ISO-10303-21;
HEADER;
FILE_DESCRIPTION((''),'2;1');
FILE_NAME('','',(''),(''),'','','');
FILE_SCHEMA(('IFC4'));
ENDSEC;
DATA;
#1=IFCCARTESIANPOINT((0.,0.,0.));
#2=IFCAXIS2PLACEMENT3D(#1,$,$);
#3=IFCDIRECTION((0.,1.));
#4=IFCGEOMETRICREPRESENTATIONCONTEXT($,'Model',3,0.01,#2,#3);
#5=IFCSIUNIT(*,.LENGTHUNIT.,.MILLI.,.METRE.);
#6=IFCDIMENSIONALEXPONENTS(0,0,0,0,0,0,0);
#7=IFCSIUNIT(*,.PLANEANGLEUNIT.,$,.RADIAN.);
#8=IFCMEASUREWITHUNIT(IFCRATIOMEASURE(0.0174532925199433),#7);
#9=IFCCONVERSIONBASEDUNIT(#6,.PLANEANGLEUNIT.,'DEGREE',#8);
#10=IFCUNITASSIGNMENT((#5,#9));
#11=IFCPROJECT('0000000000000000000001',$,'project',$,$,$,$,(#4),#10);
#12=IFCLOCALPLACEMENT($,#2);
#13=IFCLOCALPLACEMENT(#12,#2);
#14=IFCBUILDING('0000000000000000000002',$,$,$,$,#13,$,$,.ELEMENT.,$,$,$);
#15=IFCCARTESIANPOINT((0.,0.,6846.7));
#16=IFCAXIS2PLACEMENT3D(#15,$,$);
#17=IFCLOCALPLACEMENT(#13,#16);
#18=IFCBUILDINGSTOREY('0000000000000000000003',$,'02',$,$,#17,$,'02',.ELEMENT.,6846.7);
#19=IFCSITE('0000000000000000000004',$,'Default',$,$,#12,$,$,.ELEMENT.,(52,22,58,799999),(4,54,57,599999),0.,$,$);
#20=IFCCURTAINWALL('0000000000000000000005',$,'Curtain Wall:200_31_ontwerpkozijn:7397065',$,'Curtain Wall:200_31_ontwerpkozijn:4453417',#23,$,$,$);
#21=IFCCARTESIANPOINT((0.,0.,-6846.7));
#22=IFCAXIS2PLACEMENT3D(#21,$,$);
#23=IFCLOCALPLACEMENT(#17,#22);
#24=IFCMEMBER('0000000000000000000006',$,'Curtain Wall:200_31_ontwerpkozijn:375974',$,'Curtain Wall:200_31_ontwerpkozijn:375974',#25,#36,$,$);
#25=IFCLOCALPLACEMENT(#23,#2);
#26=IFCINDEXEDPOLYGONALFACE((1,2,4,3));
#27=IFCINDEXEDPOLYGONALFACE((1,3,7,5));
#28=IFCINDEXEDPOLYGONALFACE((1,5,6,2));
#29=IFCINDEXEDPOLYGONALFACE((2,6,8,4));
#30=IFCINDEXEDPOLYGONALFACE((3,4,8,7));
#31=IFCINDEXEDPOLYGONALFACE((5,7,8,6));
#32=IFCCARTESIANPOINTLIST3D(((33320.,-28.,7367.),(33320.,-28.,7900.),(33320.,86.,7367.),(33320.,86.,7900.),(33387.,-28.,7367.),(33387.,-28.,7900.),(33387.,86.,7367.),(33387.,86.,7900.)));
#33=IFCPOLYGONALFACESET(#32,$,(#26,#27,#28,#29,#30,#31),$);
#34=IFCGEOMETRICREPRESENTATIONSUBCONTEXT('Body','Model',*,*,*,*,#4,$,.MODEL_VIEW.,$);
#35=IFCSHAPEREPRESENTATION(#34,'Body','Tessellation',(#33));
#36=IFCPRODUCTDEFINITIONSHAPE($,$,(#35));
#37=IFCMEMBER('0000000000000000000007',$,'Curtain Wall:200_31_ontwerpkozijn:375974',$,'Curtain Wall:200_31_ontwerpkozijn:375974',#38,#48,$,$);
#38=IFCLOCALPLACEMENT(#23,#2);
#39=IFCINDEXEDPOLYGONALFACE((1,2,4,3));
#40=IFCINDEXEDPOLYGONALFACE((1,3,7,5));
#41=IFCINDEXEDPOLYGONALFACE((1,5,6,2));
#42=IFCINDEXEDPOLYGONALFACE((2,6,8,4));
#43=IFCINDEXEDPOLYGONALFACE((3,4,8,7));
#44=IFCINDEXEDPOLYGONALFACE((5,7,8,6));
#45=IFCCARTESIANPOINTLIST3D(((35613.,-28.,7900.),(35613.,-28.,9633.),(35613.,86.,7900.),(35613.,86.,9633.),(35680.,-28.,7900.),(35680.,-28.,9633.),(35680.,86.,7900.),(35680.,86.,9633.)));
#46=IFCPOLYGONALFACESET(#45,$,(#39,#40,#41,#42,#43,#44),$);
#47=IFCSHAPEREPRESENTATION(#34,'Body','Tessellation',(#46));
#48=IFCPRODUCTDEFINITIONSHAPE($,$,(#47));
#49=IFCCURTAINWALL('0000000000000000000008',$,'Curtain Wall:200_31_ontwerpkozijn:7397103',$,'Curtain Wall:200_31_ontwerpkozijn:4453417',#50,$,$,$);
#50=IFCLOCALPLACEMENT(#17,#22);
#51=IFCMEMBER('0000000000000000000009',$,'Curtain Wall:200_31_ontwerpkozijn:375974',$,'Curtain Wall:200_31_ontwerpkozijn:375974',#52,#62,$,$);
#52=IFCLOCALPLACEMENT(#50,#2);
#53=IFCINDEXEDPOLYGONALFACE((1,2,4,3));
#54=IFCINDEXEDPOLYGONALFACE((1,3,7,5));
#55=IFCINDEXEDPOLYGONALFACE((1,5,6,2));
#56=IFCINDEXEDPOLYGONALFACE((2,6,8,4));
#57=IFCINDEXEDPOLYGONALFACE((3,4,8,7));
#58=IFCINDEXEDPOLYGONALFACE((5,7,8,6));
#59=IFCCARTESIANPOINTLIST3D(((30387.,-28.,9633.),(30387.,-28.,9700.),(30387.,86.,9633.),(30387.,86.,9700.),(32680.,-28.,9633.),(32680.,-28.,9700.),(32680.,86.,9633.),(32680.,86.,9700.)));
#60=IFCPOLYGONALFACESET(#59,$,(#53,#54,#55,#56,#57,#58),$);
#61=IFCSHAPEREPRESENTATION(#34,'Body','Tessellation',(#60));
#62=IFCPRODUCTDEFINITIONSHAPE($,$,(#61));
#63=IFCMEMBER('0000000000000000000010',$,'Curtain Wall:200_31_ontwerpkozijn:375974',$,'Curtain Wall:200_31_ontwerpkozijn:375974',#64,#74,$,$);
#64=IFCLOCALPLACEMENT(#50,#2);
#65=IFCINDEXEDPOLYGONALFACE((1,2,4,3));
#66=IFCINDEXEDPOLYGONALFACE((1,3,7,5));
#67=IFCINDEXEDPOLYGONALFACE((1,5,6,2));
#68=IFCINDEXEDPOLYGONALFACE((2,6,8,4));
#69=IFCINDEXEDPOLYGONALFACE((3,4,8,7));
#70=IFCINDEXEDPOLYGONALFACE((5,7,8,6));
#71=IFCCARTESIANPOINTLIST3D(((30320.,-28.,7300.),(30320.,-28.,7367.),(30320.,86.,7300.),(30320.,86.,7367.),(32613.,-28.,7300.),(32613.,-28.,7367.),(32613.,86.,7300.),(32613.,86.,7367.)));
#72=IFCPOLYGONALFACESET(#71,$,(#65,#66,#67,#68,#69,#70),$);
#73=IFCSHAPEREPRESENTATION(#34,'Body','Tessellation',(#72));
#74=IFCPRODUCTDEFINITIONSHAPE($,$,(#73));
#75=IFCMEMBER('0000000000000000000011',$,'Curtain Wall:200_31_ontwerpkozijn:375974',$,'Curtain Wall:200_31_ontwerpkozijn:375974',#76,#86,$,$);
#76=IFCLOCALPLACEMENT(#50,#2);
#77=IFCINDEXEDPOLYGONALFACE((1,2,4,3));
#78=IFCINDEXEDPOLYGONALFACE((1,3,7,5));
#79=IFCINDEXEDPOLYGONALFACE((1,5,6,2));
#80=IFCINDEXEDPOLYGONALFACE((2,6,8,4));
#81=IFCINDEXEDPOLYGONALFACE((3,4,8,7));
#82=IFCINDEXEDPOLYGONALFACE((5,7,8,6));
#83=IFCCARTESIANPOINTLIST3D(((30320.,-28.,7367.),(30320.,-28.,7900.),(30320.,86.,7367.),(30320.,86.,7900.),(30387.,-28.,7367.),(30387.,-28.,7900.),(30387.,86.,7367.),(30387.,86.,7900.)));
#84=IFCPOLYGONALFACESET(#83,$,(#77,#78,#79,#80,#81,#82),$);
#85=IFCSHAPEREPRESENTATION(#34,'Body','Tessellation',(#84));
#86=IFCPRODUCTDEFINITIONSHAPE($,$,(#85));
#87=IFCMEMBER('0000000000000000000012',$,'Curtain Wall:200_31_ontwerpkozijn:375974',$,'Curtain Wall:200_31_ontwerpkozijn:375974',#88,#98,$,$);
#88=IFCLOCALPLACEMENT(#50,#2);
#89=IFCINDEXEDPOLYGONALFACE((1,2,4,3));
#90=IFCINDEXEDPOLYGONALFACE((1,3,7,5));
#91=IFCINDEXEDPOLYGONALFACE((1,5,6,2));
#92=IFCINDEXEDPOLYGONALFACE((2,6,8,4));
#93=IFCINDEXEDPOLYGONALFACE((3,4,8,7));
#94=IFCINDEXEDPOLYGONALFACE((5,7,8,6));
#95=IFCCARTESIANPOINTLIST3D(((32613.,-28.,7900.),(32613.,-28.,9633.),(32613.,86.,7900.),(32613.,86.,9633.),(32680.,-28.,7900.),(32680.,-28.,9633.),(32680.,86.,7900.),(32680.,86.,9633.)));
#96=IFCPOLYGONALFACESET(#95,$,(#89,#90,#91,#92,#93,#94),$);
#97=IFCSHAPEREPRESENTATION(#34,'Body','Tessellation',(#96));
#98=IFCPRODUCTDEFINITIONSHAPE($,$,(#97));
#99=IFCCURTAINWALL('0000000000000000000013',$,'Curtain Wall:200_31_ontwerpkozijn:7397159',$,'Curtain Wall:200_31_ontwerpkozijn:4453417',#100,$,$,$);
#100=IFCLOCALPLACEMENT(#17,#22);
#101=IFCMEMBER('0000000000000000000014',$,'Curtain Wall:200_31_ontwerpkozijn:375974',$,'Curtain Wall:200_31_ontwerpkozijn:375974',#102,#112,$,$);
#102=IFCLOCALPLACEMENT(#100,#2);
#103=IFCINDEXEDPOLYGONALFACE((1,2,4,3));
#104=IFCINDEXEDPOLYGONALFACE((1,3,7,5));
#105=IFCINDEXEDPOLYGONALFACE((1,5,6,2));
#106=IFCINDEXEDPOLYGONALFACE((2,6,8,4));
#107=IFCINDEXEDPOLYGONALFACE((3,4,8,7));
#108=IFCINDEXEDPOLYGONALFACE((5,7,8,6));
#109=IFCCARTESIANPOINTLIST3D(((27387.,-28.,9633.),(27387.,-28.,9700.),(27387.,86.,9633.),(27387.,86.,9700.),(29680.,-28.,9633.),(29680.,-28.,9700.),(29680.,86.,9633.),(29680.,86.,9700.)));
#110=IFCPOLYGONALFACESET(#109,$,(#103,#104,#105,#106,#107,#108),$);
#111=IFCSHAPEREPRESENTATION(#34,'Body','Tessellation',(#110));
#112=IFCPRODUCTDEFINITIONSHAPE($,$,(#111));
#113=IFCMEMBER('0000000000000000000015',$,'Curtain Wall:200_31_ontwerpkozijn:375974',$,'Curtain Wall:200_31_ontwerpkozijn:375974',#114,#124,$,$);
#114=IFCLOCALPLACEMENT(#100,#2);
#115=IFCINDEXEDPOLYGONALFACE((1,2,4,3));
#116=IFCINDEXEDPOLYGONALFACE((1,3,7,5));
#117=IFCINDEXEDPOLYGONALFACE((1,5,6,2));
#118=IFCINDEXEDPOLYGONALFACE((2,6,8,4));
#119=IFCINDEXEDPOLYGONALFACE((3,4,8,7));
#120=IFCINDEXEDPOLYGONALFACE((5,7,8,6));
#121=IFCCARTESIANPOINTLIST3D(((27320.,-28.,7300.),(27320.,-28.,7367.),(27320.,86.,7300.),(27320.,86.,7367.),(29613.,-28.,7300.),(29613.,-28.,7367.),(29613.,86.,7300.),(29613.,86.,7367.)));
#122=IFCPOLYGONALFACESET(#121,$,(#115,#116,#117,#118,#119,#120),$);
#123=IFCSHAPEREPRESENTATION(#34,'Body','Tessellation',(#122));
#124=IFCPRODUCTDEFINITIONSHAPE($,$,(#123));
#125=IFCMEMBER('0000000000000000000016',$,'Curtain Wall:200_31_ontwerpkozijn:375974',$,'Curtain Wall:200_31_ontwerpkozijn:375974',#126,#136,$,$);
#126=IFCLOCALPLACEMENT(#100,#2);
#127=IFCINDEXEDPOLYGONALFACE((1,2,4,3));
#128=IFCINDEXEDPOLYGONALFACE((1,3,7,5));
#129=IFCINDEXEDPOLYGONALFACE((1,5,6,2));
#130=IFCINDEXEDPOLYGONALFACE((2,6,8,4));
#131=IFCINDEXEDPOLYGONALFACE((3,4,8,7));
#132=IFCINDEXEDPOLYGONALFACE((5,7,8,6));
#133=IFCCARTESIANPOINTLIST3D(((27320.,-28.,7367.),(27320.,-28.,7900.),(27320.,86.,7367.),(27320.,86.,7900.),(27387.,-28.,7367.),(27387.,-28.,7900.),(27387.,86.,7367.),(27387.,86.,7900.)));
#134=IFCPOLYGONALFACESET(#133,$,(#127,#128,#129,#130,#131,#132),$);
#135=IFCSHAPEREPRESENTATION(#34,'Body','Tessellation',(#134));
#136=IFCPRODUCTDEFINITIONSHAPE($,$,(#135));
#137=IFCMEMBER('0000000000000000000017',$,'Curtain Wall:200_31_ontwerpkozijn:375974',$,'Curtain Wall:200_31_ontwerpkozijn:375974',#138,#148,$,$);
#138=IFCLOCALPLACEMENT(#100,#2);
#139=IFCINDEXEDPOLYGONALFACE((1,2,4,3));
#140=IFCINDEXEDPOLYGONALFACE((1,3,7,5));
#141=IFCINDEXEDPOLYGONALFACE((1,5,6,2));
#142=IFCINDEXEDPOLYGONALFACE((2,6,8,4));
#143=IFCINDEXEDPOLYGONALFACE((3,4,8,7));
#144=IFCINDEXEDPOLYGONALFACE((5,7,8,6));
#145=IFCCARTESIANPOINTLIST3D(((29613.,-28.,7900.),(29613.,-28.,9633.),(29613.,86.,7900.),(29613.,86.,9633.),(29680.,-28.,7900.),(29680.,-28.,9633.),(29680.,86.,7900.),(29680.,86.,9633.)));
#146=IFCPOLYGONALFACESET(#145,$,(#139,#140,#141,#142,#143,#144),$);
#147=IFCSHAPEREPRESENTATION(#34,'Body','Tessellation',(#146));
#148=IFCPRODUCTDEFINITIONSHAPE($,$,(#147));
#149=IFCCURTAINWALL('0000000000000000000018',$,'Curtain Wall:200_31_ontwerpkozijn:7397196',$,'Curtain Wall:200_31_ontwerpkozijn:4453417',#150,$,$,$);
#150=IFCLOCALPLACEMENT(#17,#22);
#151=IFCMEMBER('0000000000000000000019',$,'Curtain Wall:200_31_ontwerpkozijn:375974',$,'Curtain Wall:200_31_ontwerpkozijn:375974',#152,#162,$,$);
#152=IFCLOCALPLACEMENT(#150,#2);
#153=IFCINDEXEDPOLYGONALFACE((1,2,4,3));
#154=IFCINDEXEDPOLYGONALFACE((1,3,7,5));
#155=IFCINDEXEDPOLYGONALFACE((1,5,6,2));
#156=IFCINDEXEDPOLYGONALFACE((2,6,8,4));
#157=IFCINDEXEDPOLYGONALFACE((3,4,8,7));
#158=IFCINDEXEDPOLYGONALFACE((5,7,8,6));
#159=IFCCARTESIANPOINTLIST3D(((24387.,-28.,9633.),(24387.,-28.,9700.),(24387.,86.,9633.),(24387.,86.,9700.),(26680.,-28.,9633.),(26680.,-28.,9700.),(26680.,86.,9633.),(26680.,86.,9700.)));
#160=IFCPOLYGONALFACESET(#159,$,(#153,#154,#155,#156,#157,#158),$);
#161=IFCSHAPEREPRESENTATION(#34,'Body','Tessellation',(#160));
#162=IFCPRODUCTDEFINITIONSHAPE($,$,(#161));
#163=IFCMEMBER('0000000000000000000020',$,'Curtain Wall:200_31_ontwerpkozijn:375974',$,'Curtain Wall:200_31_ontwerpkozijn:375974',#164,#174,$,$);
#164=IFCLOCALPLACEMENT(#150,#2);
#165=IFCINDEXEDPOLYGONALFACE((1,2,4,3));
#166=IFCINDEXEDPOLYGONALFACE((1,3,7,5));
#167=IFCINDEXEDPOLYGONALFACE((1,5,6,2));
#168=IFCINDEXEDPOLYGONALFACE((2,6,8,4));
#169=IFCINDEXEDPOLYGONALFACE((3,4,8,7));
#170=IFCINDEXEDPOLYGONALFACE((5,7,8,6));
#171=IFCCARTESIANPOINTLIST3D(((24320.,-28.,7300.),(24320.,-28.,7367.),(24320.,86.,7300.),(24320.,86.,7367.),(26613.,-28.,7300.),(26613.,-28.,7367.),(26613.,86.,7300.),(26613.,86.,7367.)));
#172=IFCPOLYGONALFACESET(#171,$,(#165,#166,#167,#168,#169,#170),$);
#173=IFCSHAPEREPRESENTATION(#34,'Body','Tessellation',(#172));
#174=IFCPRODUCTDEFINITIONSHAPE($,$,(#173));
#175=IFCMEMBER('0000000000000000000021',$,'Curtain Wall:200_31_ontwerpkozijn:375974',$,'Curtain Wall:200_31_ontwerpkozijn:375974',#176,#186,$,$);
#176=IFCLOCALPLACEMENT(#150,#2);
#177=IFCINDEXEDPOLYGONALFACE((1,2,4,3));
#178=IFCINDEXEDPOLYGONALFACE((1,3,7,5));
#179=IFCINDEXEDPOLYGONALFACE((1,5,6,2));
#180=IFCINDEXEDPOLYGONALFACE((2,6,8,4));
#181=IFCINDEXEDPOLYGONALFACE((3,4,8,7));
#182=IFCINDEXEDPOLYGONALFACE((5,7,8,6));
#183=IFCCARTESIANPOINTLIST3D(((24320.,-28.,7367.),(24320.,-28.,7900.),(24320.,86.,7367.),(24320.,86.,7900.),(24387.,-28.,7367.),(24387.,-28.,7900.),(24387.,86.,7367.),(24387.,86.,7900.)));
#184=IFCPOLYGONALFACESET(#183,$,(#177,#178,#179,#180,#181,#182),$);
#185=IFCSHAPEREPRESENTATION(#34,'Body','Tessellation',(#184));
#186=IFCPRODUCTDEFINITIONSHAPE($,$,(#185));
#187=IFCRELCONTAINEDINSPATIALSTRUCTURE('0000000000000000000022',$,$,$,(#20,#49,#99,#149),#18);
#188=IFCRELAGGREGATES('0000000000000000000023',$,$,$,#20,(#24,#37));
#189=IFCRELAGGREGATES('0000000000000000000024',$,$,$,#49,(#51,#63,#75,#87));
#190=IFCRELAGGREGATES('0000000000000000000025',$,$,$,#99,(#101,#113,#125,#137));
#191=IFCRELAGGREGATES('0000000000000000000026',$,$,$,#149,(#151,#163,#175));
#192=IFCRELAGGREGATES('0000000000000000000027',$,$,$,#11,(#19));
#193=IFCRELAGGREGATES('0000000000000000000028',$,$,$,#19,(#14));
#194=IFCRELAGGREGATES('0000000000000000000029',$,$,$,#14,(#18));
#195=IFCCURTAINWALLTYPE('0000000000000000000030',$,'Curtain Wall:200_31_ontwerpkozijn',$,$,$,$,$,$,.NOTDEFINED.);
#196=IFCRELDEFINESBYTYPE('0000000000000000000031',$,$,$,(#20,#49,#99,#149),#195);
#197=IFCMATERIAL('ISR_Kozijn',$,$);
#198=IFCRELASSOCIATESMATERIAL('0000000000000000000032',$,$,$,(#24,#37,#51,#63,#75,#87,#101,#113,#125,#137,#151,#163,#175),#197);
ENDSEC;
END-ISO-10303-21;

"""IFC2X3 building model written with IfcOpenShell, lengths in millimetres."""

from ifc_helpers import new_model, entity, si_unit, converted_unit, direction, frame, frame_2d, origin, origin_2d_with_axis, place, context, subcontext, project, spatial, rectangle, extrude, material, type_object, element, aggregate, save


model = new_model("IFC2X3")

# Units and contexts
model_context = context("Model", 3, precision=0.01, world=origin(), true_north=direction((0.0, 1.0)))
body_context = subcontext(model_context, "Body", "Model", "MODEL_VIEW")
ifc_project = project(units=[si_unit("LENGTHUNIT", "METRE", prefix="MILLI"), converted_unit("PLANEANGLEUNIT", "DEGREE", entity("IfcRatioMeasure", 0.0174532925199433), si_unit("PLANEANGLEUNIT", "RADIAN"), dimensions=[0, 0, 0, 0, 0, 0, 0])], contexts=[model_context])

# Site, building, storey
site_placement = place(None, origin())
site = spatial("IfcSite", under=ifc_project, at=site_placement, Name="Default", CompositionType="ELEMENT", RefLatitude=(52, 22, 58, 799999), RefLongitude=(4, 54, 57, 599999), RefElevation=0.0)
building_placement = place(site_placement, origin())
building = spatial("IfcBuilding", under=site, at=building_placement, CompositionType="ELEMENT")
storey_placement = place(building_placement, frame((0.0, 0.0, 6846.7)))
storey = spatial("IfcBuildingStorey", under=building, at=storey_placement, Name="02", LongName="02", CompositionType="ELEMENT", Elevation=6846.7)

# Curtain walls, members
curtain_wall_type = type_object("IfcCurtainWallType", Name="Curtain Wall:200_31_ontwerpkozijn", PredefinedType="NOTDEFINED")
ifc_material = material(Name="ISR_Kozijn")
curtain_wall_1_placement = place(storey_placement, frame((0.0, 0.0, -6846.7)))
curtain_wall_1 = element("IfcCurtainWall", 1, at=curtain_wall_1_placement, inside=storey, type_object=curtain_wall_type, Name="Curtain Wall:200_31_ontwerpkozijn:7397065", ObjectType="Curtain Wall:200_31_ontwerpkozijn:4453417")
member_1_placement = place(curtain_wall_1_placement, origin())
member_1 = element("IfcMember", 2, at=member_1_placement, material=ifc_material, Name="Curtain Wall:200_31_ontwerpkozijn:375974", ObjectType="Curtain Wall:200_31_ontwerpkozijn:375974", context=body_context, shape_type="SweptSolid", body=[
    extrude(rectangle(XDim=67.0, YDim=114.0, at=origin_2d_with_axis()), frame((33353.5, 29.0, 7367.0), z_axis=(0.0, 0.0, 1.0), x_axis=(-1.0, 0.0, 0.0)), (0.0, 0.0, 1.0), 533.0),
])
member_2_placement = place(curtain_wall_1_placement, origin())
member_2 = element("IfcMember", 3, at=member_2_placement, material=ifc_material, Name="Curtain Wall:200_31_ontwerpkozijn:375974", ObjectType="Curtain Wall:200_31_ontwerpkozijn:375974", context=body_context, shape_type="SweptSolid", body=[
    extrude(rectangle(XDim=67.0, YDim=114.0, at=origin_2d_with_axis()), frame((35646.5, 29.0, 9633.0), z_axis=(0.0, 0.0, -1.0), x_axis=(-1.0, 0.0, 0.0)), (0.0, 0.0, 1.0), 1733.0),
])
aggregate(curtain_wall_1, [member_1, member_2])
curtain_wall_2_placement = place(storey_placement, frame((0.0, 0.0, -6846.7)))
curtain_wall_2 = element("IfcCurtainWall", 4, at=curtain_wall_2_placement, inside=storey, type_object=curtain_wall_type, Name="Curtain Wall:200_31_ontwerpkozijn:7397103", ObjectType="Curtain Wall:200_31_ontwerpkozijn:4453417")
member_3_placement = place(curtain_wall_2_placement, origin())
member_3 = element("IfcMember", 5, at=member_3_placement, material=ifc_material, Name="Curtain Wall:200_31_ontwerpkozijn:375974", ObjectType="Curtain Wall:200_31_ontwerpkozijn:375974", context=body_context, shape_type="SweptSolid", body=[
    extrude(rectangle(XDim=67.0, YDim=114.0, at=frame_2d((0.0, 0.0), x_axis=(1.0, 0.0))), frame((30387.0, 29.0, 9666.5), z_axis=(1.0, 0.0, 0.0), x_axis=(0.0, 0.0, -1.0)), (0.0, 0.0, 1.0), 2293.0),
])
member_4_placement = place(curtain_wall_2_placement, origin())
member_4 = element("IfcMember", 6, at=member_4_placement, material=ifc_material, Name="Curtain Wall:200_31_ontwerpkozijn:375974", ObjectType="Curtain Wall:200_31_ontwerpkozijn:375974", context=body_context, shape_type="SweptSolid", body=[
    extrude(rectangle(XDim=67.0, YDim=114.0, at=frame_2d((0.0, 0.0), x_axis=(1.0, 0.0))), frame((32613.0, 29.0, 7333.5), z_axis=(-1.0, 0.0, 0.0), x_axis=(0.0, 0.0, -1.0)), (0.0, 0.0, 1.0), 2293.0),
])
member_5_placement = place(curtain_wall_2_placement, origin())
member_5 = element("IfcMember", 7, at=member_5_placement, material=ifc_material, Name="Curtain Wall:200_31_ontwerpkozijn:375974", ObjectType="Curtain Wall:200_31_ontwerpkozijn:375974", context=body_context, shape_type="SweptSolid", body=[
    extrude(rectangle(XDim=67.0, YDim=114.0, at=origin_2d_with_axis()), frame((30353.5, 29.0, 7367.0), z_axis=(0.0, 0.0, 1.0), x_axis=(-1.0, 0.0, 0.0)), (0.0, 0.0, 1.0), 533.0),
])
member_6_placement = place(curtain_wall_2_placement, origin())
member_6 = element("IfcMember", 8, at=member_6_placement, material=ifc_material, Name="Curtain Wall:200_31_ontwerpkozijn:375974", ObjectType="Curtain Wall:200_31_ontwerpkozijn:375974", context=body_context, shape_type="SweptSolid", body=[
    extrude(rectangle(XDim=67.0, YDim=114.0, at=origin_2d_with_axis()), frame((32646.5, 29.0, 9633.0), z_axis=(0.0, 0.0, -1.0), x_axis=(-1.0, 0.0, 0.0)), (0.0, 0.0, 1.0), 1733.0),
])
aggregate(curtain_wall_2, [member_3, member_4, member_5, member_6])
curtain_wall_3_placement = place(storey_placement, frame((0.0, 0.0, -6846.7)))
curtain_wall_3 = element("IfcCurtainWall", 9, at=curtain_wall_3_placement, inside=storey, type_object=curtain_wall_type, Name="Curtain Wall:200_31_ontwerpkozijn:7397159", ObjectType="Curtain Wall:200_31_ontwerpkozijn:4453417")
member_7_placement = place(curtain_wall_3_placement, origin())
member_7 = element("IfcMember", 10, at=member_7_placement, material=ifc_material, Name="Curtain Wall:200_31_ontwerpkozijn:375974", ObjectType="Curtain Wall:200_31_ontwerpkozijn:375974", context=body_context, shape_type="SweptSolid", body=[
    extrude(rectangle(XDim=67.0, YDim=114.0, at=frame_2d((0.0, 0.0), x_axis=(1.0, 0.0))), frame((27387.0, 29.0, 9666.5), z_axis=(1.0, 0.0, 0.0), x_axis=(0.0, 0.0, -1.0)), (0.0, 0.0, 1.0), 2293.0),
])
member_8_placement = place(curtain_wall_3_placement, origin())
member_8 = element("IfcMember", 11, at=member_8_placement, material=ifc_material, Name="Curtain Wall:200_31_ontwerpkozijn:375974", ObjectType="Curtain Wall:200_31_ontwerpkozijn:375974", context=body_context, shape_type="SweptSolid", body=[
    extrude(rectangle(XDim=67.0, YDim=114.0, at=frame_2d((0.0, 0.0), x_axis=(1.0, 0.0))), frame((29613.0, 29.0, 7333.5), z_axis=(-1.0, 0.0, 0.0), x_axis=(0.0, 0.0, -1.0)), (0.0, 0.0, 1.0), 2293.0),
])
member_9_placement = place(curtain_wall_3_placement, origin())
member_9 = element("IfcMember", 12, at=member_9_placement, material=ifc_material, Name="Curtain Wall:200_31_ontwerpkozijn:375974", ObjectType="Curtain Wall:200_31_ontwerpkozijn:375974", context=body_context, shape_type="SweptSolid", body=[
    extrude(rectangle(XDim=67.0, YDim=114.0, at=origin_2d_with_axis()), frame((27353.5, 29.0, 7367.0), z_axis=(0.0, 0.0, 1.0), x_axis=(-1.0, 0.0, 0.0)), (0.0, 0.0, 1.0), 533.0),
])
member_10_placement = place(curtain_wall_3_placement, origin())
member_10 = element("IfcMember", 13, at=member_10_placement, material=ifc_material, Name="Curtain Wall:200_31_ontwerpkozijn:375974", ObjectType="Curtain Wall:200_31_ontwerpkozijn:375974", context=body_context, shape_type="SweptSolid", body=[
    extrude(rectangle(XDim=67.0, YDim=114.0, at=origin_2d_with_axis()), frame((29646.5, 29.0, 9633.0), z_axis=(0.0, 0.0, -1.0), x_axis=(-1.0, 0.0, 0.0)), (0.0, 0.0, 1.0), 1733.0),
])
aggregate(curtain_wall_3, [member_7, member_8, member_9, member_10])
curtain_wall_4_placement = place(storey_placement, frame((0.0, 0.0, -6846.7)))
curtain_wall_4 = element("IfcCurtainWall", 14, at=curtain_wall_4_placement, inside=storey, type_object=curtain_wall_type, Name="Curtain Wall:200_31_ontwerpkozijn:7397196", ObjectType="Curtain Wall:200_31_ontwerpkozijn:4453417")
member_11_placement = place(curtain_wall_4_placement, origin())
member_11 = element("IfcMember", 15, at=member_11_placement, material=ifc_material, Name="Curtain Wall:200_31_ontwerpkozijn:375974", ObjectType="Curtain Wall:200_31_ontwerpkozijn:375974", context=body_context, shape_type="SweptSolid", body=[
    extrude(rectangle(XDim=67.0, YDim=114.0, at=frame_2d((0.0, 0.0), x_axis=(1.0, 0.0))), frame((24387.0, 29.0, 9666.5), z_axis=(1.0, 0.0, 0.0), x_axis=(0.0, 0.0, -1.0)), (0.0, 0.0, 1.0), 2293.0),
])
member_12_placement = place(curtain_wall_4_placement, origin())
member_12 = element("IfcMember", 16, at=member_12_placement, material=ifc_material, Name="Curtain Wall:200_31_ontwerpkozijn:375974", ObjectType="Curtain Wall:200_31_ontwerpkozijn:375974", context=body_context, shape_type="SweptSolid", body=[
    extrude(rectangle(XDim=67.0, YDim=114.0, at=frame_2d((0.0, 0.0), x_axis=(1.0, 0.0))), frame((26613.0, 29.0, 7333.5), z_axis=(-1.0, 0.0, 0.0), x_axis=(0.0, 0.0, -1.0)), (0.0, 0.0, 1.0), 2293.0),
])
member_13_placement = place(curtain_wall_4_placement, origin())
member_13 = element("IfcMember", 17, at=member_13_placement, material=ifc_material, Name="Curtain Wall:200_31_ontwerpkozijn:375974", ObjectType="Curtain Wall:200_31_ontwerpkozijn:375974", context=body_context, shape_type="SweptSolid", body=[
    extrude(rectangle(XDim=67.0, YDim=114.0, at=origin_2d_with_axis()), frame((24353.5, 29.0, 7367.0), z_axis=(0.0, 0.0, 1.0), x_axis=(-1.0, 0.0, 0.0)), (0.0, 0.0, 1.0), 533.0),
])
aggregate(curtain_wall_4, [member_11, member_12, member_13])

save(model, "model.ifc")
